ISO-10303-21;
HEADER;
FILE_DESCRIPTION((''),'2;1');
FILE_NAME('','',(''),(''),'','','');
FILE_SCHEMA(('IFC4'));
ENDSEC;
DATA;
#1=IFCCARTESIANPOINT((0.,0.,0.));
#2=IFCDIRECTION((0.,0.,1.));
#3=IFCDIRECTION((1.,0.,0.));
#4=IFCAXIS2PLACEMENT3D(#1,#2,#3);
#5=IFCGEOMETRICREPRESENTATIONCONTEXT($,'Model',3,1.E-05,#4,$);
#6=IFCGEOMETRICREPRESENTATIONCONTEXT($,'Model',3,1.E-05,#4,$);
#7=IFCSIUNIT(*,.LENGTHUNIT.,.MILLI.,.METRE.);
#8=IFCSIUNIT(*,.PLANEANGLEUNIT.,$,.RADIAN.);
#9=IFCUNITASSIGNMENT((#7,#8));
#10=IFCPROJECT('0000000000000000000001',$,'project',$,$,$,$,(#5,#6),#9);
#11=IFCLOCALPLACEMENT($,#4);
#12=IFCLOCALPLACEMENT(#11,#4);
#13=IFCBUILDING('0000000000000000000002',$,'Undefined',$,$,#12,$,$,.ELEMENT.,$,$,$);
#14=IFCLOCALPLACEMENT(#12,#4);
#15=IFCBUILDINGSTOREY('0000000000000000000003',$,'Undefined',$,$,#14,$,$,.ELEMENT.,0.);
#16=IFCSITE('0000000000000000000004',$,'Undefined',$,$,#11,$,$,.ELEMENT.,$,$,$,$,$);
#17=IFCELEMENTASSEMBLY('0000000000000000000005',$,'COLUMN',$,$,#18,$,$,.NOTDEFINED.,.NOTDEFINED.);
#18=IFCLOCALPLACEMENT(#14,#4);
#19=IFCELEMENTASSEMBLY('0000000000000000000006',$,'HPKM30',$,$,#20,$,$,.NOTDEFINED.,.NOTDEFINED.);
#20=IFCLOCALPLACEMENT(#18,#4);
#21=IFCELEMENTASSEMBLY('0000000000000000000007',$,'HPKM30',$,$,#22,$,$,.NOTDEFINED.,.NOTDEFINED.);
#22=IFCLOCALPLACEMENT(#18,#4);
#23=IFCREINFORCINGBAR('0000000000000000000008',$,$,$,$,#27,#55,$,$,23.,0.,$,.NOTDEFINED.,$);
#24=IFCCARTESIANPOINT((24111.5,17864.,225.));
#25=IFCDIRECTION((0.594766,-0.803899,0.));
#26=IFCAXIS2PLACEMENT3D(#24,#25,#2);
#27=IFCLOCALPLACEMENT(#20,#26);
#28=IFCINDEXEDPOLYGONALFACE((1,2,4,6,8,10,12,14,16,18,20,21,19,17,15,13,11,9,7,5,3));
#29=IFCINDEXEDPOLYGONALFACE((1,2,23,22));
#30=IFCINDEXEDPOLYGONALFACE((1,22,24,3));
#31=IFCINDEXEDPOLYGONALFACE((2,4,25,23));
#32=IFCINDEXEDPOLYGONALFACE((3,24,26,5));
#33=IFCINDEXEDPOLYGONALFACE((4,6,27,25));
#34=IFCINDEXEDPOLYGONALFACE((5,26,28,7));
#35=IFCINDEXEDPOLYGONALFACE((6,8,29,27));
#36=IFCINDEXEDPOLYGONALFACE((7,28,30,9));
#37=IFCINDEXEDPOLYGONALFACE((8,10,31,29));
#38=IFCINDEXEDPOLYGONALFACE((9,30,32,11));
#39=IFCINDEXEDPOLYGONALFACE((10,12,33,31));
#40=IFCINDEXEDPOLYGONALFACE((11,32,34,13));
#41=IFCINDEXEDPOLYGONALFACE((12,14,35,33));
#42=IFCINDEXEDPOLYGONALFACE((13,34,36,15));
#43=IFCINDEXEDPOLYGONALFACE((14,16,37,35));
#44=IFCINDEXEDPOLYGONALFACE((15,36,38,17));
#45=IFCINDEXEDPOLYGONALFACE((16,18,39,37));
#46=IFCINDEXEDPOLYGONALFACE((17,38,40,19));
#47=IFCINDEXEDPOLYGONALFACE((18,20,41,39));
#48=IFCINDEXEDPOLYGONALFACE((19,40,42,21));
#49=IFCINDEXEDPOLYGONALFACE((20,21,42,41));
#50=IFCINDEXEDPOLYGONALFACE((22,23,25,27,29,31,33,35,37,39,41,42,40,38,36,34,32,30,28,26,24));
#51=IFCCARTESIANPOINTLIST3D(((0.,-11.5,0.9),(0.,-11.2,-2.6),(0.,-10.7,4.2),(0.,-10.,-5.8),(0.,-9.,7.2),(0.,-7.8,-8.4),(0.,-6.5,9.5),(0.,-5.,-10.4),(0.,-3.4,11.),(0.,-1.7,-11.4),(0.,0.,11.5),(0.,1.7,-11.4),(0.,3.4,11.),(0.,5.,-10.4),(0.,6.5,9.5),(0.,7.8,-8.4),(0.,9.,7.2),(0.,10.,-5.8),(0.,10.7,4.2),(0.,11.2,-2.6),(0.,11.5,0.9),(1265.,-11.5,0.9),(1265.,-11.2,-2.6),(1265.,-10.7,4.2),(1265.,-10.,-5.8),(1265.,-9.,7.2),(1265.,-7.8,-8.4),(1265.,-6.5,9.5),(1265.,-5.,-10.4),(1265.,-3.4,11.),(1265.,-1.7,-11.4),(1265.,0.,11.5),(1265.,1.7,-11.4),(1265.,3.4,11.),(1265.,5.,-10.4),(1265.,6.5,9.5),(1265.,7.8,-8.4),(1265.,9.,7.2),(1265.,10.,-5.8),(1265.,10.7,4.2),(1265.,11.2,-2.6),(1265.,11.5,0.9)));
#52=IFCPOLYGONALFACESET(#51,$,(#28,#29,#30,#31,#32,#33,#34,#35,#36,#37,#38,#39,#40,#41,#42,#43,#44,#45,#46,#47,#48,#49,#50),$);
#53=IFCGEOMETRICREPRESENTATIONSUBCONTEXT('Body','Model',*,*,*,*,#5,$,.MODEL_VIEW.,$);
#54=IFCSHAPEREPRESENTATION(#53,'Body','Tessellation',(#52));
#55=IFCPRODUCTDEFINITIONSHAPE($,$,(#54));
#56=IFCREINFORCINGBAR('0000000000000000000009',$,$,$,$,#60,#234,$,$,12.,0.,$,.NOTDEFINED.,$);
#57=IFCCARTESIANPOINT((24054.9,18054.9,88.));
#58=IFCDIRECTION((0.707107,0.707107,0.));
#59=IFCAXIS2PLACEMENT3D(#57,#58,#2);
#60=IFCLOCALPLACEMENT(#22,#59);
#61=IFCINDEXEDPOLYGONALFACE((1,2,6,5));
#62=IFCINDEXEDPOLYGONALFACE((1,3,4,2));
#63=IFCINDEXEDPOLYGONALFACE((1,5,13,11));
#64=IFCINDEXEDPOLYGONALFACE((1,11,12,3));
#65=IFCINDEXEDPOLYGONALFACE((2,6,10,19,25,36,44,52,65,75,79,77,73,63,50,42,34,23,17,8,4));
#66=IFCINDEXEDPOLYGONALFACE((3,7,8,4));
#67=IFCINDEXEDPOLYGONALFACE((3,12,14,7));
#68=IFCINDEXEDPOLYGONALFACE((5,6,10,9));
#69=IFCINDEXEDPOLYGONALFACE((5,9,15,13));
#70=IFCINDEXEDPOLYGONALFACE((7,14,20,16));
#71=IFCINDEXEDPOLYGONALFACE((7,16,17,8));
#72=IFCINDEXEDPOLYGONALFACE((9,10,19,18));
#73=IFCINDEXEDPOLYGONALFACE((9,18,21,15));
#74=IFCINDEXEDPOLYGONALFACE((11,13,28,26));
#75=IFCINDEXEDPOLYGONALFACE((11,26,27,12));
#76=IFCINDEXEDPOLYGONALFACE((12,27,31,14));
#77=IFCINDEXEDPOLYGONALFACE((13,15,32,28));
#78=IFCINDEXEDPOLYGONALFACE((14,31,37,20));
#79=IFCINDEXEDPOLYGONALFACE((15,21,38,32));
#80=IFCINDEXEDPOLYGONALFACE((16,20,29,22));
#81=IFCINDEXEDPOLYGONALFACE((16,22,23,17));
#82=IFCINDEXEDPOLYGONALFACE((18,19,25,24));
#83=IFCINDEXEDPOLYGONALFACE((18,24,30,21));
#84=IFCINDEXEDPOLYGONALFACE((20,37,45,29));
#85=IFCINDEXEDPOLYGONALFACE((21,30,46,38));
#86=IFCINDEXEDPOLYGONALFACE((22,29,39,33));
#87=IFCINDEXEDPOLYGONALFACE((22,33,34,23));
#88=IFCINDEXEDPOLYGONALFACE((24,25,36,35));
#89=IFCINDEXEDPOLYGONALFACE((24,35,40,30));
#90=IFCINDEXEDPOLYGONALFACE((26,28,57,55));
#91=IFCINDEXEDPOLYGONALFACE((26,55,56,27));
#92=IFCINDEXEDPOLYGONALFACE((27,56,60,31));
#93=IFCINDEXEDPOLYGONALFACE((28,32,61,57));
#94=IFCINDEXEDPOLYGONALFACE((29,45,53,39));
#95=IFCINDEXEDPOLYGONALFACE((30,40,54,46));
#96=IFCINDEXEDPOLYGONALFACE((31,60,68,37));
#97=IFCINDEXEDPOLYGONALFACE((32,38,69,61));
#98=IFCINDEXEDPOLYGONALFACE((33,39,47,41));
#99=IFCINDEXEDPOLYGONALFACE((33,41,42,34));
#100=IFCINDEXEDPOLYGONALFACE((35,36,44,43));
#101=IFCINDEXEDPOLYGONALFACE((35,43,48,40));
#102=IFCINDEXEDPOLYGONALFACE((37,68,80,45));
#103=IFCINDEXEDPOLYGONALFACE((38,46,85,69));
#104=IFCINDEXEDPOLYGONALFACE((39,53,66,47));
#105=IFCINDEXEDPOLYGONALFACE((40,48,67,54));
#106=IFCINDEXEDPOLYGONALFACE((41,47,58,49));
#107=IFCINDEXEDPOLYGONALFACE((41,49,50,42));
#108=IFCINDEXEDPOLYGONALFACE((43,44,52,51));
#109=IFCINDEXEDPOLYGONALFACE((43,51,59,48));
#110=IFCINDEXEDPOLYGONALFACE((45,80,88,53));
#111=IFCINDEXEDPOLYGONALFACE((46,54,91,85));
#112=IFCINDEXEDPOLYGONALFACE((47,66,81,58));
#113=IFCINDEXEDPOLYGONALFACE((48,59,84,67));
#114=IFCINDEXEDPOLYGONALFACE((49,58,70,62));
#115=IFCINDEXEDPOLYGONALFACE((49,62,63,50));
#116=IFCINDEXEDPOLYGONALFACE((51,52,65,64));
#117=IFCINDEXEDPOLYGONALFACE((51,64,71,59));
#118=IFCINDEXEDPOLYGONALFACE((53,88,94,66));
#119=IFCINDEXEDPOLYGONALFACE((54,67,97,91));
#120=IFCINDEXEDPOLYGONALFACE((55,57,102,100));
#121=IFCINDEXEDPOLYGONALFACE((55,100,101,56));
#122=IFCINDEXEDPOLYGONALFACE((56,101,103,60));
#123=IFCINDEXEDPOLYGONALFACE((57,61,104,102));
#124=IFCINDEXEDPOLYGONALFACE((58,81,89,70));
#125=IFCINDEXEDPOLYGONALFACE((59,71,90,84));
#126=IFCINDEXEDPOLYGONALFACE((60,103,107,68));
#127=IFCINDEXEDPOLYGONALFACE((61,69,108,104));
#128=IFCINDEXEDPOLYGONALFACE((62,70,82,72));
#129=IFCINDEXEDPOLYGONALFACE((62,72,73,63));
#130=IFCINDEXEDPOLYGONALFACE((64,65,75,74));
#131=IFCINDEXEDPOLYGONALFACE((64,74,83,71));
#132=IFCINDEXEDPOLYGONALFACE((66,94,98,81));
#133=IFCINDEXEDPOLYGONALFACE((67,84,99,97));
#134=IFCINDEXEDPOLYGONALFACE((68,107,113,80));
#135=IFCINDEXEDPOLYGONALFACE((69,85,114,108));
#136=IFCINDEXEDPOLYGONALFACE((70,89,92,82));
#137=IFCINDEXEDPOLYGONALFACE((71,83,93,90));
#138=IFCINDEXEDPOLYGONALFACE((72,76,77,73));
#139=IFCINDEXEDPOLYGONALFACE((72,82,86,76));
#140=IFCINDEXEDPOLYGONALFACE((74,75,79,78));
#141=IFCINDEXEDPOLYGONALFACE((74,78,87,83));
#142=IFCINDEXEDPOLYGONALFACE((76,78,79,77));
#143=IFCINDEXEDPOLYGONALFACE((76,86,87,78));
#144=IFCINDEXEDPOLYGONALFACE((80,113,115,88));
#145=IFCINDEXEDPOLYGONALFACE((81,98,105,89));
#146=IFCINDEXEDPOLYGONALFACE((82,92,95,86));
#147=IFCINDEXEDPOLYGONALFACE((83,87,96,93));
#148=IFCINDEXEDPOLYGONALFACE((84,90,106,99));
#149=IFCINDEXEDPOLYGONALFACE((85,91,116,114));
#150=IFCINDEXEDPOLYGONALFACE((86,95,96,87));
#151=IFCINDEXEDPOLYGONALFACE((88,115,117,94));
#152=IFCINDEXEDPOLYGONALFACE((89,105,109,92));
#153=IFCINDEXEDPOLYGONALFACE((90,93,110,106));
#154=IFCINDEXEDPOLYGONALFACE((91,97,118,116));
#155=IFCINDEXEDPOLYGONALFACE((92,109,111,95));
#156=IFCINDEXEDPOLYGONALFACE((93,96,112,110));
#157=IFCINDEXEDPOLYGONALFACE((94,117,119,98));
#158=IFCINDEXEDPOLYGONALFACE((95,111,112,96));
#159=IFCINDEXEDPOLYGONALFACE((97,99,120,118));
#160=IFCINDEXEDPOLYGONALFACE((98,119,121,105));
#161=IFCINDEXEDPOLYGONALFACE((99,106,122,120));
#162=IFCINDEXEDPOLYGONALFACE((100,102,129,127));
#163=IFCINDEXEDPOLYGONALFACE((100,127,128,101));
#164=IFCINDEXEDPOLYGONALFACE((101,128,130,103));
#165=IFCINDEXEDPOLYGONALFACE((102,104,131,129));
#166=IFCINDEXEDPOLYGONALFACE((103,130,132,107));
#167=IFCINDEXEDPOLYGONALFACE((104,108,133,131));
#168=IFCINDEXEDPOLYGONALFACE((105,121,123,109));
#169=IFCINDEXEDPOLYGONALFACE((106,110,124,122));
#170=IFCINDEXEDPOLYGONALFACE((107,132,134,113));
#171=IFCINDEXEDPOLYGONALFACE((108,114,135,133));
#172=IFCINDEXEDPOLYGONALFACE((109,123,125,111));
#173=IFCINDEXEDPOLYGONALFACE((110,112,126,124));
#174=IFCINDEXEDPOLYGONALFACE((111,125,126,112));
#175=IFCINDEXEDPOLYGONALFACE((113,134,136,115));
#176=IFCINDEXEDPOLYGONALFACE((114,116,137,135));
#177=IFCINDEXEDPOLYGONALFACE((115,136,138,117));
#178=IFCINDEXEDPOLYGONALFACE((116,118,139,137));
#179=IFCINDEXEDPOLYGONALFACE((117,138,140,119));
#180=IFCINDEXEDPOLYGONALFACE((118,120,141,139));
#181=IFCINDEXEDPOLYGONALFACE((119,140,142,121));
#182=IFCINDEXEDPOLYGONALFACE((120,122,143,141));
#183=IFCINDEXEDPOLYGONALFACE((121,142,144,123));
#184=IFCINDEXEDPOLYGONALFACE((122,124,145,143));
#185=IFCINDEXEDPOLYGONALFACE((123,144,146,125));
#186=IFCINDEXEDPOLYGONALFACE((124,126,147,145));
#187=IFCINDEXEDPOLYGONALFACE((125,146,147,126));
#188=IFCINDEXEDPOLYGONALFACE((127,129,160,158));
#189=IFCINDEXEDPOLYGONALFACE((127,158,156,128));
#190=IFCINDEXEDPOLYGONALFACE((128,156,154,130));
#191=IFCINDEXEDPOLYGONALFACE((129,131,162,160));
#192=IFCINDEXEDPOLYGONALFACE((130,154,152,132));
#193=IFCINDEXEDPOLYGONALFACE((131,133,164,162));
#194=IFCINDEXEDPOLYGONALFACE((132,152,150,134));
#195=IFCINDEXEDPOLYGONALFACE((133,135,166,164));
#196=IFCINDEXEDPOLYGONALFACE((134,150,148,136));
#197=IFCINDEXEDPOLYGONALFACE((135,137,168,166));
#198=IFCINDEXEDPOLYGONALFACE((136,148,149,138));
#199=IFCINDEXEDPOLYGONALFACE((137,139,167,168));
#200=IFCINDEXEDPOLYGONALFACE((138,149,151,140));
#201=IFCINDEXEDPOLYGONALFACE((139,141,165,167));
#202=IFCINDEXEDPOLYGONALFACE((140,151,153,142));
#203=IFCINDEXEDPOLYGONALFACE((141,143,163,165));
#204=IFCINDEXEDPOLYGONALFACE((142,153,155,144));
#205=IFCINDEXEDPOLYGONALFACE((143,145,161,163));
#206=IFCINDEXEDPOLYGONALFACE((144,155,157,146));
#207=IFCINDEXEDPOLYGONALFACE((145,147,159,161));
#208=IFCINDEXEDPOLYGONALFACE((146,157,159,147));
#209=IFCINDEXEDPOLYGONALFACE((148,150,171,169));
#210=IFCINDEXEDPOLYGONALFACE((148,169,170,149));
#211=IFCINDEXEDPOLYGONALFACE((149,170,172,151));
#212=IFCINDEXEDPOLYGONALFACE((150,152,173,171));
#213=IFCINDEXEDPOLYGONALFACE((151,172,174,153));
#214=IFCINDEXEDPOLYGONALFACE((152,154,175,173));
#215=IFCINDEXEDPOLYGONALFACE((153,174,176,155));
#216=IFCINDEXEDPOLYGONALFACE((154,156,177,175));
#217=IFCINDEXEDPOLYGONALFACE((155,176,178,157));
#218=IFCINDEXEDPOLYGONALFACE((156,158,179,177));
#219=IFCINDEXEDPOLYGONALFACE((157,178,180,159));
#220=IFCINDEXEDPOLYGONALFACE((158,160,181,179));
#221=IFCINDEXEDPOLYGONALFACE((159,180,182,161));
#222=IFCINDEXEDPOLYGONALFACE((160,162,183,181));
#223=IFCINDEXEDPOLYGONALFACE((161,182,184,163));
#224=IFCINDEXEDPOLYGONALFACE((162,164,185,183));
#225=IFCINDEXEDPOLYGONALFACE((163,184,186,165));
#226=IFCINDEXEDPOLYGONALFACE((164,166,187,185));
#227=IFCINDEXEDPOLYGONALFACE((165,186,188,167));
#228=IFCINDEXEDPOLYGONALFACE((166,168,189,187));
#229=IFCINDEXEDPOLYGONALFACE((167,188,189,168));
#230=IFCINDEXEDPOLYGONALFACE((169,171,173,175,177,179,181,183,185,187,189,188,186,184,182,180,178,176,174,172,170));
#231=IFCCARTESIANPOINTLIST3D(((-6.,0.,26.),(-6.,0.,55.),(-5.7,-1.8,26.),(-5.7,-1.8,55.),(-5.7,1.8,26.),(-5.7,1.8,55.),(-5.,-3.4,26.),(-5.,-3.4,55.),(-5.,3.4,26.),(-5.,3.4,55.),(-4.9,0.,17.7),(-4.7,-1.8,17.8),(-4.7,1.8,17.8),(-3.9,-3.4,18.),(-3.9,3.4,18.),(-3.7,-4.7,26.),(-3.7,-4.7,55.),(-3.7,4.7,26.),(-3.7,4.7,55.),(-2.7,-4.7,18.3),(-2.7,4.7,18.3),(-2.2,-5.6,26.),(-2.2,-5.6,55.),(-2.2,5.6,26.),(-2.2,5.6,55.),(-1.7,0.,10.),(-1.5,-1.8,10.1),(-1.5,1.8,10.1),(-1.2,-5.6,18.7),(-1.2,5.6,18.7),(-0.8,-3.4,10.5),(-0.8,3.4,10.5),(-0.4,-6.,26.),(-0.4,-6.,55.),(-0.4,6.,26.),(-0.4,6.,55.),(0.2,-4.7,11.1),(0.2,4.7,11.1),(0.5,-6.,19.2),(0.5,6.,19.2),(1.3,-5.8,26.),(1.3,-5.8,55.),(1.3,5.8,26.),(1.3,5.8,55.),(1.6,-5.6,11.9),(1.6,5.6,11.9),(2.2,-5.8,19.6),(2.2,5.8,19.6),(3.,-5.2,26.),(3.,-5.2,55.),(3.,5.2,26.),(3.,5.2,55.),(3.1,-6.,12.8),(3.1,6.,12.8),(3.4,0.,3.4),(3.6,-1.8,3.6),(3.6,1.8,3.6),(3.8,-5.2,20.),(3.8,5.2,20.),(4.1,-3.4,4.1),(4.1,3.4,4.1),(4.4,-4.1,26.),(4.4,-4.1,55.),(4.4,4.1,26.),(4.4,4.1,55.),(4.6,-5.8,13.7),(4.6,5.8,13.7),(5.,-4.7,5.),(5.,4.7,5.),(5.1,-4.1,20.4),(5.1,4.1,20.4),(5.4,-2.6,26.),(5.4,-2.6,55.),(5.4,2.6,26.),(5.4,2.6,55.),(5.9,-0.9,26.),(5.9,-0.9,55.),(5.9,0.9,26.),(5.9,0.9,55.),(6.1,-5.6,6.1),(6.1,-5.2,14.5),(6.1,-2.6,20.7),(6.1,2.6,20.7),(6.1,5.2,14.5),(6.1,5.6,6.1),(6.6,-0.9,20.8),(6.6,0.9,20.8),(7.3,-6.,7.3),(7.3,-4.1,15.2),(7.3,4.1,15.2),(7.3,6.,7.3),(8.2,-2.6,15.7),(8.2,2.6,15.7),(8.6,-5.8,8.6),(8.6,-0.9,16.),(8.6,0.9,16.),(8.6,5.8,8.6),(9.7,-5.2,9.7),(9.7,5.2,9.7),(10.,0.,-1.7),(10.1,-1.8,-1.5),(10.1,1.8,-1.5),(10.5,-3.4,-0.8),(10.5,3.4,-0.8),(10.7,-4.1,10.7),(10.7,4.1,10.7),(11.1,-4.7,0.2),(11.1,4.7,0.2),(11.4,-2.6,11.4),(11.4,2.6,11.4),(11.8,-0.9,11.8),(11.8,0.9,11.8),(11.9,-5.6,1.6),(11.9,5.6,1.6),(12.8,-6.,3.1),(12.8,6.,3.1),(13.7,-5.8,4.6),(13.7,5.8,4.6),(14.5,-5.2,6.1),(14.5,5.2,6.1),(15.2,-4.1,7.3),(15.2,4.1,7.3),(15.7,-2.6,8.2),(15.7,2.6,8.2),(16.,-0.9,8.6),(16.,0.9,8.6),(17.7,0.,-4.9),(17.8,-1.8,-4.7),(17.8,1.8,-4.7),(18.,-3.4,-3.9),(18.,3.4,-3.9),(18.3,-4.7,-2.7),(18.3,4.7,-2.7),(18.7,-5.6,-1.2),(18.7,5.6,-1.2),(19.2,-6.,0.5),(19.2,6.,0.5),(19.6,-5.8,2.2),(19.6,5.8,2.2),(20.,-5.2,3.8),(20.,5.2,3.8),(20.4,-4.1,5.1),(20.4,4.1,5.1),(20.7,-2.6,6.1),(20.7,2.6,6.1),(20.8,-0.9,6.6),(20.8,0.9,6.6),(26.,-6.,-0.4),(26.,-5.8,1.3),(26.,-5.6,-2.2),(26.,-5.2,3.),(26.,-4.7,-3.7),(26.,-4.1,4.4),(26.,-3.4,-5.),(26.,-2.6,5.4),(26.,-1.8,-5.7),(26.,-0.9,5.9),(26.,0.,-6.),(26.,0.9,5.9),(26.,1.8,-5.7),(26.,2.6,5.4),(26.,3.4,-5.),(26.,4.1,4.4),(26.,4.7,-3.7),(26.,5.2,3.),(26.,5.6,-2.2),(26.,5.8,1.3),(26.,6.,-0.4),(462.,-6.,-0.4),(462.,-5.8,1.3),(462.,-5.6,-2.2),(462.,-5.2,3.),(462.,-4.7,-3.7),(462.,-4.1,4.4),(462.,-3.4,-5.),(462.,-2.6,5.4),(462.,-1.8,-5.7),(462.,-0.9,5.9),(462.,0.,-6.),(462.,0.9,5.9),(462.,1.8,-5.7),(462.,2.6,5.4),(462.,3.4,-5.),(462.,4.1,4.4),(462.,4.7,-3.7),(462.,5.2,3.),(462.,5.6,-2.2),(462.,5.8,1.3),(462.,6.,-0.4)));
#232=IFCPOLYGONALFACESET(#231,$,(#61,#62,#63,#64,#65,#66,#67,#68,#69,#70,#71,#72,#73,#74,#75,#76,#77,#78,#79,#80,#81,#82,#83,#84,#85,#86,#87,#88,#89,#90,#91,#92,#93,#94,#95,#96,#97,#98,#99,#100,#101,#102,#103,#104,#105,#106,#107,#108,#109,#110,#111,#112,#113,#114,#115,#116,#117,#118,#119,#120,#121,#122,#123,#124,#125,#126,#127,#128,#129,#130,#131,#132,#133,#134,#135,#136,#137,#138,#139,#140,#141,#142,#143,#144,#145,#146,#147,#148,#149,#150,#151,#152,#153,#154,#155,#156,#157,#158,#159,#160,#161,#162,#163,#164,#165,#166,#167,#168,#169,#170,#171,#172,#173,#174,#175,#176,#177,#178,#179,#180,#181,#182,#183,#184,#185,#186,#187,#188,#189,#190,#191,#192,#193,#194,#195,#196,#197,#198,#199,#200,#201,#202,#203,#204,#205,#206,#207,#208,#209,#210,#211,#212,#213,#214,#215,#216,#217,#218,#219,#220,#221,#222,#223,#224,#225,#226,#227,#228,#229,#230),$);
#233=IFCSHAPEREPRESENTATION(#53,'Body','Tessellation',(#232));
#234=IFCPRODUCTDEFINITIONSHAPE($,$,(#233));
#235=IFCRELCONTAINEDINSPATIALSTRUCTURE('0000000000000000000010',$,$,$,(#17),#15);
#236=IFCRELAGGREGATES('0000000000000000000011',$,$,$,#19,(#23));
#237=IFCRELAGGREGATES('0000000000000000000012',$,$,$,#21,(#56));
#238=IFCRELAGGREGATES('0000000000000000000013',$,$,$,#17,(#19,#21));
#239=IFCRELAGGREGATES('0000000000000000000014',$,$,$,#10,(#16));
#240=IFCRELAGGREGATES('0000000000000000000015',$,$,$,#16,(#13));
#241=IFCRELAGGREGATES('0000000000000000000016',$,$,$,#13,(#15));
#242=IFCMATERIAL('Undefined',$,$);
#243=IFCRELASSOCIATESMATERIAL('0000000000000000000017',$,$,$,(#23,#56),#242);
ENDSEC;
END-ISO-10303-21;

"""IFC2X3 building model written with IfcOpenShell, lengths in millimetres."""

from ifc_helpers import new_model, entity, si_unit, frame, origin_with_axes, place, context, subcontext, project, spatial, source, transform, mapped, material, element, aggregate, save


model = new_model("IFC2X3")

# Units and contexts
model_context_1 = context("Model", 3, precision=1e-05, world=origin_with_axes())
model_context_2 = context("Model", 3, precision=1e-05, world=origin_with_axes())
body_context = subcontext(model_context_1, "Body", "Model", "MODEL_VIEW")
ifc_project = project(units=[si_unit("LENGTHUNIT", "METRE", prefix="MILLI"), si_unit("PLANEANGLEUNIT", "RADIAN")], contexts=[model_context_1, model_context_2])

# Site, building, storey
site_placement = place(None, origin_with_axes())
site = spatial("IfcSite", under=ifc_project, at=site_placement, Name="Undefined", CompositionType="ELEMENT")
building_placement = place(site_placement, origin_with_axes())
building = spatial("IfcBuilding", under=site, at=building_placement, Name="Undefined", CompositionType="ELEMENT")
storey_placement = place(building_placement, origin_with_axes())
storey = spatial("IfcBuildingStorey", under=building, at=storey_placement, Name="Undefined", CompositionType="ELEMENT", Elevation=0.0)

# Element assemblies
assembly_1_placement = place(storey_placement, origin_with_axes())
assembly_1 = element("IfcElementAssembly", 1, at=assembly_1_placement, inside=storey, Name="COLUMN", AssemblyPlace="NOTDEFINED", PredefinedType="NOTDEFINED")
assembly_2_placement = place(assembly_1_placement, origin_with_axes())
assembly_2 = element("IfcElementAssembly", 2, at=assembly_2_placement, Name="HPKM30", AssemblyPlace="NOTDEFINED", PredefinedType="NOTDEFINED")
assembly_3_placement = place(assembly_1_placement, origin_with_axes())
assembly_3 = element("IfcElementAssembly", 3, at=assembly_3_placement, Name="HPKM30", AssemblyPlace="NOTDEFINED", PredefinedType="NOTDEFINED")
ifc_material_1 = material(Name="Undefined")

# Reinforcing bars
shared_shape_1 = source(origin_with_axes(), body_context, "Body", "AdvancedSweptSolid", [
    entity("IfcSweptDiskSolid", entity("IfcTrimmedCurve", entity("IfcLine", entity("IfcCartesianPoint", [0.0, 0.0, 0.0]), entity("IfcVector", entity("IfcDirection", [1.0, 0.0, 0.0]), 1.0)), [entity("IfcParameterValue", 0.0)], [entity("IfcParameterValue", 1265.0)], True, "PARAMETER"), 11.5, None, 0.0, 1265.0),
])
reinforcing_bar_1_placement = place(assembly_2_placement, frame((24111.5, 17864.0, 225.0), z_axis=(0.594766, -0.803899, 0.0), x_axis=(0.0, 0.0, 1.0)))
reinforcing_bar_1 = element("IfcReinforcingBar", 4, at=reinforcing_bar_1_placement, material=ifc_material_1, BarRole="NOTDEFINED", CrossSectionArea=0.0, NominalDiameter=23.0, context=body_context, shape_type="MappedRepresentation", body=[
    mapped(shared_shape_1, transform((0.0, 0.0, 0.0))),
])
aggregate(assembly_2, [reinforcing_bar_1])
shared_shape_2 = source(origin_with_axes(), body_context, "Body", "AdvancedSweptSolid", [
    entity("IfcSweptDiskSolid", entity("IfcCompositeCurve", [entity("IfcCompositeCurveSegment", "CONTINUOUS", True, entity("IfcTrimmedCurve", entity("IfcLine", entity("IfcCartesianPoint", [0.0, 0.0, 0.0]), entity("IfcVector", entity("IfcDirection", [0.0, 0.0, -1.0]), 1.0)), [entity("IfcParameterValue", 0.0)], [entity("IfcParameterValue", 29.0)], True, "PARAMETER")), entity("IfcCompositeCurveSegment", "CONTINUOUS", True, entity("IfcTrimmedCurve", entity("IfcCircle", entity("IfcAxis2Placement3D", entity("IfcCartesianPoint", [26.0, 0.0, -29.0]), entity("IfcDirection", [0.0, -1.0, 0.0]), entity("IfcDirection", [-1.0, 0.0, 0.0])), 26.0), [entity("IfcParameterValue", 0.0)], [entity("IfcParameterValue", 1.570796)], True, "PARAMETER")), entity("IfcCompositeCurveSegment", "DISCONTINUOUS", True, entity("IfcTrimmedCurve", entity("IfcLine", entity("IfcCartesianPoint", [26.0, 0.0, -55.0]), entity("IfcVector", entity("IfcDirection", [1.0, 0.0, 0.0]), 1.0)), [entity("IfcParameterValue", 0.0)], [entity("IfcParameterValue", 436.0)], True, "PARAMETER"))], False), 6.0, None, 0.0, 466.6),
])
reinforcing_bar_2_placement = place(assembly_3_placement, frame((24054.9, 18054.9, 88.0), z_axis=(0.707107, 0.707107, 0.0), x_axis=(0.0, 0.0, 1.0)))
reinforcing_bar_2 = element("IfcReinforcingBar", 5, at=reinforcing_bar_2_placement, material=ifc_material_1, BarRole="NOTDEFINED", CrossSectionArea=0.0, NominalDiameter=12.0, context=body_context, shape_type="MappedRepresentation", body=[
    mapped(shared_shape_2, transform((0.0, 0.0, 55.0))),
])
aggregate(assembly_3, [reinforcing_bar_2])
aggregate(assembly_1, [assembly_2, assembly_3])

save(model, "model.ifc")
